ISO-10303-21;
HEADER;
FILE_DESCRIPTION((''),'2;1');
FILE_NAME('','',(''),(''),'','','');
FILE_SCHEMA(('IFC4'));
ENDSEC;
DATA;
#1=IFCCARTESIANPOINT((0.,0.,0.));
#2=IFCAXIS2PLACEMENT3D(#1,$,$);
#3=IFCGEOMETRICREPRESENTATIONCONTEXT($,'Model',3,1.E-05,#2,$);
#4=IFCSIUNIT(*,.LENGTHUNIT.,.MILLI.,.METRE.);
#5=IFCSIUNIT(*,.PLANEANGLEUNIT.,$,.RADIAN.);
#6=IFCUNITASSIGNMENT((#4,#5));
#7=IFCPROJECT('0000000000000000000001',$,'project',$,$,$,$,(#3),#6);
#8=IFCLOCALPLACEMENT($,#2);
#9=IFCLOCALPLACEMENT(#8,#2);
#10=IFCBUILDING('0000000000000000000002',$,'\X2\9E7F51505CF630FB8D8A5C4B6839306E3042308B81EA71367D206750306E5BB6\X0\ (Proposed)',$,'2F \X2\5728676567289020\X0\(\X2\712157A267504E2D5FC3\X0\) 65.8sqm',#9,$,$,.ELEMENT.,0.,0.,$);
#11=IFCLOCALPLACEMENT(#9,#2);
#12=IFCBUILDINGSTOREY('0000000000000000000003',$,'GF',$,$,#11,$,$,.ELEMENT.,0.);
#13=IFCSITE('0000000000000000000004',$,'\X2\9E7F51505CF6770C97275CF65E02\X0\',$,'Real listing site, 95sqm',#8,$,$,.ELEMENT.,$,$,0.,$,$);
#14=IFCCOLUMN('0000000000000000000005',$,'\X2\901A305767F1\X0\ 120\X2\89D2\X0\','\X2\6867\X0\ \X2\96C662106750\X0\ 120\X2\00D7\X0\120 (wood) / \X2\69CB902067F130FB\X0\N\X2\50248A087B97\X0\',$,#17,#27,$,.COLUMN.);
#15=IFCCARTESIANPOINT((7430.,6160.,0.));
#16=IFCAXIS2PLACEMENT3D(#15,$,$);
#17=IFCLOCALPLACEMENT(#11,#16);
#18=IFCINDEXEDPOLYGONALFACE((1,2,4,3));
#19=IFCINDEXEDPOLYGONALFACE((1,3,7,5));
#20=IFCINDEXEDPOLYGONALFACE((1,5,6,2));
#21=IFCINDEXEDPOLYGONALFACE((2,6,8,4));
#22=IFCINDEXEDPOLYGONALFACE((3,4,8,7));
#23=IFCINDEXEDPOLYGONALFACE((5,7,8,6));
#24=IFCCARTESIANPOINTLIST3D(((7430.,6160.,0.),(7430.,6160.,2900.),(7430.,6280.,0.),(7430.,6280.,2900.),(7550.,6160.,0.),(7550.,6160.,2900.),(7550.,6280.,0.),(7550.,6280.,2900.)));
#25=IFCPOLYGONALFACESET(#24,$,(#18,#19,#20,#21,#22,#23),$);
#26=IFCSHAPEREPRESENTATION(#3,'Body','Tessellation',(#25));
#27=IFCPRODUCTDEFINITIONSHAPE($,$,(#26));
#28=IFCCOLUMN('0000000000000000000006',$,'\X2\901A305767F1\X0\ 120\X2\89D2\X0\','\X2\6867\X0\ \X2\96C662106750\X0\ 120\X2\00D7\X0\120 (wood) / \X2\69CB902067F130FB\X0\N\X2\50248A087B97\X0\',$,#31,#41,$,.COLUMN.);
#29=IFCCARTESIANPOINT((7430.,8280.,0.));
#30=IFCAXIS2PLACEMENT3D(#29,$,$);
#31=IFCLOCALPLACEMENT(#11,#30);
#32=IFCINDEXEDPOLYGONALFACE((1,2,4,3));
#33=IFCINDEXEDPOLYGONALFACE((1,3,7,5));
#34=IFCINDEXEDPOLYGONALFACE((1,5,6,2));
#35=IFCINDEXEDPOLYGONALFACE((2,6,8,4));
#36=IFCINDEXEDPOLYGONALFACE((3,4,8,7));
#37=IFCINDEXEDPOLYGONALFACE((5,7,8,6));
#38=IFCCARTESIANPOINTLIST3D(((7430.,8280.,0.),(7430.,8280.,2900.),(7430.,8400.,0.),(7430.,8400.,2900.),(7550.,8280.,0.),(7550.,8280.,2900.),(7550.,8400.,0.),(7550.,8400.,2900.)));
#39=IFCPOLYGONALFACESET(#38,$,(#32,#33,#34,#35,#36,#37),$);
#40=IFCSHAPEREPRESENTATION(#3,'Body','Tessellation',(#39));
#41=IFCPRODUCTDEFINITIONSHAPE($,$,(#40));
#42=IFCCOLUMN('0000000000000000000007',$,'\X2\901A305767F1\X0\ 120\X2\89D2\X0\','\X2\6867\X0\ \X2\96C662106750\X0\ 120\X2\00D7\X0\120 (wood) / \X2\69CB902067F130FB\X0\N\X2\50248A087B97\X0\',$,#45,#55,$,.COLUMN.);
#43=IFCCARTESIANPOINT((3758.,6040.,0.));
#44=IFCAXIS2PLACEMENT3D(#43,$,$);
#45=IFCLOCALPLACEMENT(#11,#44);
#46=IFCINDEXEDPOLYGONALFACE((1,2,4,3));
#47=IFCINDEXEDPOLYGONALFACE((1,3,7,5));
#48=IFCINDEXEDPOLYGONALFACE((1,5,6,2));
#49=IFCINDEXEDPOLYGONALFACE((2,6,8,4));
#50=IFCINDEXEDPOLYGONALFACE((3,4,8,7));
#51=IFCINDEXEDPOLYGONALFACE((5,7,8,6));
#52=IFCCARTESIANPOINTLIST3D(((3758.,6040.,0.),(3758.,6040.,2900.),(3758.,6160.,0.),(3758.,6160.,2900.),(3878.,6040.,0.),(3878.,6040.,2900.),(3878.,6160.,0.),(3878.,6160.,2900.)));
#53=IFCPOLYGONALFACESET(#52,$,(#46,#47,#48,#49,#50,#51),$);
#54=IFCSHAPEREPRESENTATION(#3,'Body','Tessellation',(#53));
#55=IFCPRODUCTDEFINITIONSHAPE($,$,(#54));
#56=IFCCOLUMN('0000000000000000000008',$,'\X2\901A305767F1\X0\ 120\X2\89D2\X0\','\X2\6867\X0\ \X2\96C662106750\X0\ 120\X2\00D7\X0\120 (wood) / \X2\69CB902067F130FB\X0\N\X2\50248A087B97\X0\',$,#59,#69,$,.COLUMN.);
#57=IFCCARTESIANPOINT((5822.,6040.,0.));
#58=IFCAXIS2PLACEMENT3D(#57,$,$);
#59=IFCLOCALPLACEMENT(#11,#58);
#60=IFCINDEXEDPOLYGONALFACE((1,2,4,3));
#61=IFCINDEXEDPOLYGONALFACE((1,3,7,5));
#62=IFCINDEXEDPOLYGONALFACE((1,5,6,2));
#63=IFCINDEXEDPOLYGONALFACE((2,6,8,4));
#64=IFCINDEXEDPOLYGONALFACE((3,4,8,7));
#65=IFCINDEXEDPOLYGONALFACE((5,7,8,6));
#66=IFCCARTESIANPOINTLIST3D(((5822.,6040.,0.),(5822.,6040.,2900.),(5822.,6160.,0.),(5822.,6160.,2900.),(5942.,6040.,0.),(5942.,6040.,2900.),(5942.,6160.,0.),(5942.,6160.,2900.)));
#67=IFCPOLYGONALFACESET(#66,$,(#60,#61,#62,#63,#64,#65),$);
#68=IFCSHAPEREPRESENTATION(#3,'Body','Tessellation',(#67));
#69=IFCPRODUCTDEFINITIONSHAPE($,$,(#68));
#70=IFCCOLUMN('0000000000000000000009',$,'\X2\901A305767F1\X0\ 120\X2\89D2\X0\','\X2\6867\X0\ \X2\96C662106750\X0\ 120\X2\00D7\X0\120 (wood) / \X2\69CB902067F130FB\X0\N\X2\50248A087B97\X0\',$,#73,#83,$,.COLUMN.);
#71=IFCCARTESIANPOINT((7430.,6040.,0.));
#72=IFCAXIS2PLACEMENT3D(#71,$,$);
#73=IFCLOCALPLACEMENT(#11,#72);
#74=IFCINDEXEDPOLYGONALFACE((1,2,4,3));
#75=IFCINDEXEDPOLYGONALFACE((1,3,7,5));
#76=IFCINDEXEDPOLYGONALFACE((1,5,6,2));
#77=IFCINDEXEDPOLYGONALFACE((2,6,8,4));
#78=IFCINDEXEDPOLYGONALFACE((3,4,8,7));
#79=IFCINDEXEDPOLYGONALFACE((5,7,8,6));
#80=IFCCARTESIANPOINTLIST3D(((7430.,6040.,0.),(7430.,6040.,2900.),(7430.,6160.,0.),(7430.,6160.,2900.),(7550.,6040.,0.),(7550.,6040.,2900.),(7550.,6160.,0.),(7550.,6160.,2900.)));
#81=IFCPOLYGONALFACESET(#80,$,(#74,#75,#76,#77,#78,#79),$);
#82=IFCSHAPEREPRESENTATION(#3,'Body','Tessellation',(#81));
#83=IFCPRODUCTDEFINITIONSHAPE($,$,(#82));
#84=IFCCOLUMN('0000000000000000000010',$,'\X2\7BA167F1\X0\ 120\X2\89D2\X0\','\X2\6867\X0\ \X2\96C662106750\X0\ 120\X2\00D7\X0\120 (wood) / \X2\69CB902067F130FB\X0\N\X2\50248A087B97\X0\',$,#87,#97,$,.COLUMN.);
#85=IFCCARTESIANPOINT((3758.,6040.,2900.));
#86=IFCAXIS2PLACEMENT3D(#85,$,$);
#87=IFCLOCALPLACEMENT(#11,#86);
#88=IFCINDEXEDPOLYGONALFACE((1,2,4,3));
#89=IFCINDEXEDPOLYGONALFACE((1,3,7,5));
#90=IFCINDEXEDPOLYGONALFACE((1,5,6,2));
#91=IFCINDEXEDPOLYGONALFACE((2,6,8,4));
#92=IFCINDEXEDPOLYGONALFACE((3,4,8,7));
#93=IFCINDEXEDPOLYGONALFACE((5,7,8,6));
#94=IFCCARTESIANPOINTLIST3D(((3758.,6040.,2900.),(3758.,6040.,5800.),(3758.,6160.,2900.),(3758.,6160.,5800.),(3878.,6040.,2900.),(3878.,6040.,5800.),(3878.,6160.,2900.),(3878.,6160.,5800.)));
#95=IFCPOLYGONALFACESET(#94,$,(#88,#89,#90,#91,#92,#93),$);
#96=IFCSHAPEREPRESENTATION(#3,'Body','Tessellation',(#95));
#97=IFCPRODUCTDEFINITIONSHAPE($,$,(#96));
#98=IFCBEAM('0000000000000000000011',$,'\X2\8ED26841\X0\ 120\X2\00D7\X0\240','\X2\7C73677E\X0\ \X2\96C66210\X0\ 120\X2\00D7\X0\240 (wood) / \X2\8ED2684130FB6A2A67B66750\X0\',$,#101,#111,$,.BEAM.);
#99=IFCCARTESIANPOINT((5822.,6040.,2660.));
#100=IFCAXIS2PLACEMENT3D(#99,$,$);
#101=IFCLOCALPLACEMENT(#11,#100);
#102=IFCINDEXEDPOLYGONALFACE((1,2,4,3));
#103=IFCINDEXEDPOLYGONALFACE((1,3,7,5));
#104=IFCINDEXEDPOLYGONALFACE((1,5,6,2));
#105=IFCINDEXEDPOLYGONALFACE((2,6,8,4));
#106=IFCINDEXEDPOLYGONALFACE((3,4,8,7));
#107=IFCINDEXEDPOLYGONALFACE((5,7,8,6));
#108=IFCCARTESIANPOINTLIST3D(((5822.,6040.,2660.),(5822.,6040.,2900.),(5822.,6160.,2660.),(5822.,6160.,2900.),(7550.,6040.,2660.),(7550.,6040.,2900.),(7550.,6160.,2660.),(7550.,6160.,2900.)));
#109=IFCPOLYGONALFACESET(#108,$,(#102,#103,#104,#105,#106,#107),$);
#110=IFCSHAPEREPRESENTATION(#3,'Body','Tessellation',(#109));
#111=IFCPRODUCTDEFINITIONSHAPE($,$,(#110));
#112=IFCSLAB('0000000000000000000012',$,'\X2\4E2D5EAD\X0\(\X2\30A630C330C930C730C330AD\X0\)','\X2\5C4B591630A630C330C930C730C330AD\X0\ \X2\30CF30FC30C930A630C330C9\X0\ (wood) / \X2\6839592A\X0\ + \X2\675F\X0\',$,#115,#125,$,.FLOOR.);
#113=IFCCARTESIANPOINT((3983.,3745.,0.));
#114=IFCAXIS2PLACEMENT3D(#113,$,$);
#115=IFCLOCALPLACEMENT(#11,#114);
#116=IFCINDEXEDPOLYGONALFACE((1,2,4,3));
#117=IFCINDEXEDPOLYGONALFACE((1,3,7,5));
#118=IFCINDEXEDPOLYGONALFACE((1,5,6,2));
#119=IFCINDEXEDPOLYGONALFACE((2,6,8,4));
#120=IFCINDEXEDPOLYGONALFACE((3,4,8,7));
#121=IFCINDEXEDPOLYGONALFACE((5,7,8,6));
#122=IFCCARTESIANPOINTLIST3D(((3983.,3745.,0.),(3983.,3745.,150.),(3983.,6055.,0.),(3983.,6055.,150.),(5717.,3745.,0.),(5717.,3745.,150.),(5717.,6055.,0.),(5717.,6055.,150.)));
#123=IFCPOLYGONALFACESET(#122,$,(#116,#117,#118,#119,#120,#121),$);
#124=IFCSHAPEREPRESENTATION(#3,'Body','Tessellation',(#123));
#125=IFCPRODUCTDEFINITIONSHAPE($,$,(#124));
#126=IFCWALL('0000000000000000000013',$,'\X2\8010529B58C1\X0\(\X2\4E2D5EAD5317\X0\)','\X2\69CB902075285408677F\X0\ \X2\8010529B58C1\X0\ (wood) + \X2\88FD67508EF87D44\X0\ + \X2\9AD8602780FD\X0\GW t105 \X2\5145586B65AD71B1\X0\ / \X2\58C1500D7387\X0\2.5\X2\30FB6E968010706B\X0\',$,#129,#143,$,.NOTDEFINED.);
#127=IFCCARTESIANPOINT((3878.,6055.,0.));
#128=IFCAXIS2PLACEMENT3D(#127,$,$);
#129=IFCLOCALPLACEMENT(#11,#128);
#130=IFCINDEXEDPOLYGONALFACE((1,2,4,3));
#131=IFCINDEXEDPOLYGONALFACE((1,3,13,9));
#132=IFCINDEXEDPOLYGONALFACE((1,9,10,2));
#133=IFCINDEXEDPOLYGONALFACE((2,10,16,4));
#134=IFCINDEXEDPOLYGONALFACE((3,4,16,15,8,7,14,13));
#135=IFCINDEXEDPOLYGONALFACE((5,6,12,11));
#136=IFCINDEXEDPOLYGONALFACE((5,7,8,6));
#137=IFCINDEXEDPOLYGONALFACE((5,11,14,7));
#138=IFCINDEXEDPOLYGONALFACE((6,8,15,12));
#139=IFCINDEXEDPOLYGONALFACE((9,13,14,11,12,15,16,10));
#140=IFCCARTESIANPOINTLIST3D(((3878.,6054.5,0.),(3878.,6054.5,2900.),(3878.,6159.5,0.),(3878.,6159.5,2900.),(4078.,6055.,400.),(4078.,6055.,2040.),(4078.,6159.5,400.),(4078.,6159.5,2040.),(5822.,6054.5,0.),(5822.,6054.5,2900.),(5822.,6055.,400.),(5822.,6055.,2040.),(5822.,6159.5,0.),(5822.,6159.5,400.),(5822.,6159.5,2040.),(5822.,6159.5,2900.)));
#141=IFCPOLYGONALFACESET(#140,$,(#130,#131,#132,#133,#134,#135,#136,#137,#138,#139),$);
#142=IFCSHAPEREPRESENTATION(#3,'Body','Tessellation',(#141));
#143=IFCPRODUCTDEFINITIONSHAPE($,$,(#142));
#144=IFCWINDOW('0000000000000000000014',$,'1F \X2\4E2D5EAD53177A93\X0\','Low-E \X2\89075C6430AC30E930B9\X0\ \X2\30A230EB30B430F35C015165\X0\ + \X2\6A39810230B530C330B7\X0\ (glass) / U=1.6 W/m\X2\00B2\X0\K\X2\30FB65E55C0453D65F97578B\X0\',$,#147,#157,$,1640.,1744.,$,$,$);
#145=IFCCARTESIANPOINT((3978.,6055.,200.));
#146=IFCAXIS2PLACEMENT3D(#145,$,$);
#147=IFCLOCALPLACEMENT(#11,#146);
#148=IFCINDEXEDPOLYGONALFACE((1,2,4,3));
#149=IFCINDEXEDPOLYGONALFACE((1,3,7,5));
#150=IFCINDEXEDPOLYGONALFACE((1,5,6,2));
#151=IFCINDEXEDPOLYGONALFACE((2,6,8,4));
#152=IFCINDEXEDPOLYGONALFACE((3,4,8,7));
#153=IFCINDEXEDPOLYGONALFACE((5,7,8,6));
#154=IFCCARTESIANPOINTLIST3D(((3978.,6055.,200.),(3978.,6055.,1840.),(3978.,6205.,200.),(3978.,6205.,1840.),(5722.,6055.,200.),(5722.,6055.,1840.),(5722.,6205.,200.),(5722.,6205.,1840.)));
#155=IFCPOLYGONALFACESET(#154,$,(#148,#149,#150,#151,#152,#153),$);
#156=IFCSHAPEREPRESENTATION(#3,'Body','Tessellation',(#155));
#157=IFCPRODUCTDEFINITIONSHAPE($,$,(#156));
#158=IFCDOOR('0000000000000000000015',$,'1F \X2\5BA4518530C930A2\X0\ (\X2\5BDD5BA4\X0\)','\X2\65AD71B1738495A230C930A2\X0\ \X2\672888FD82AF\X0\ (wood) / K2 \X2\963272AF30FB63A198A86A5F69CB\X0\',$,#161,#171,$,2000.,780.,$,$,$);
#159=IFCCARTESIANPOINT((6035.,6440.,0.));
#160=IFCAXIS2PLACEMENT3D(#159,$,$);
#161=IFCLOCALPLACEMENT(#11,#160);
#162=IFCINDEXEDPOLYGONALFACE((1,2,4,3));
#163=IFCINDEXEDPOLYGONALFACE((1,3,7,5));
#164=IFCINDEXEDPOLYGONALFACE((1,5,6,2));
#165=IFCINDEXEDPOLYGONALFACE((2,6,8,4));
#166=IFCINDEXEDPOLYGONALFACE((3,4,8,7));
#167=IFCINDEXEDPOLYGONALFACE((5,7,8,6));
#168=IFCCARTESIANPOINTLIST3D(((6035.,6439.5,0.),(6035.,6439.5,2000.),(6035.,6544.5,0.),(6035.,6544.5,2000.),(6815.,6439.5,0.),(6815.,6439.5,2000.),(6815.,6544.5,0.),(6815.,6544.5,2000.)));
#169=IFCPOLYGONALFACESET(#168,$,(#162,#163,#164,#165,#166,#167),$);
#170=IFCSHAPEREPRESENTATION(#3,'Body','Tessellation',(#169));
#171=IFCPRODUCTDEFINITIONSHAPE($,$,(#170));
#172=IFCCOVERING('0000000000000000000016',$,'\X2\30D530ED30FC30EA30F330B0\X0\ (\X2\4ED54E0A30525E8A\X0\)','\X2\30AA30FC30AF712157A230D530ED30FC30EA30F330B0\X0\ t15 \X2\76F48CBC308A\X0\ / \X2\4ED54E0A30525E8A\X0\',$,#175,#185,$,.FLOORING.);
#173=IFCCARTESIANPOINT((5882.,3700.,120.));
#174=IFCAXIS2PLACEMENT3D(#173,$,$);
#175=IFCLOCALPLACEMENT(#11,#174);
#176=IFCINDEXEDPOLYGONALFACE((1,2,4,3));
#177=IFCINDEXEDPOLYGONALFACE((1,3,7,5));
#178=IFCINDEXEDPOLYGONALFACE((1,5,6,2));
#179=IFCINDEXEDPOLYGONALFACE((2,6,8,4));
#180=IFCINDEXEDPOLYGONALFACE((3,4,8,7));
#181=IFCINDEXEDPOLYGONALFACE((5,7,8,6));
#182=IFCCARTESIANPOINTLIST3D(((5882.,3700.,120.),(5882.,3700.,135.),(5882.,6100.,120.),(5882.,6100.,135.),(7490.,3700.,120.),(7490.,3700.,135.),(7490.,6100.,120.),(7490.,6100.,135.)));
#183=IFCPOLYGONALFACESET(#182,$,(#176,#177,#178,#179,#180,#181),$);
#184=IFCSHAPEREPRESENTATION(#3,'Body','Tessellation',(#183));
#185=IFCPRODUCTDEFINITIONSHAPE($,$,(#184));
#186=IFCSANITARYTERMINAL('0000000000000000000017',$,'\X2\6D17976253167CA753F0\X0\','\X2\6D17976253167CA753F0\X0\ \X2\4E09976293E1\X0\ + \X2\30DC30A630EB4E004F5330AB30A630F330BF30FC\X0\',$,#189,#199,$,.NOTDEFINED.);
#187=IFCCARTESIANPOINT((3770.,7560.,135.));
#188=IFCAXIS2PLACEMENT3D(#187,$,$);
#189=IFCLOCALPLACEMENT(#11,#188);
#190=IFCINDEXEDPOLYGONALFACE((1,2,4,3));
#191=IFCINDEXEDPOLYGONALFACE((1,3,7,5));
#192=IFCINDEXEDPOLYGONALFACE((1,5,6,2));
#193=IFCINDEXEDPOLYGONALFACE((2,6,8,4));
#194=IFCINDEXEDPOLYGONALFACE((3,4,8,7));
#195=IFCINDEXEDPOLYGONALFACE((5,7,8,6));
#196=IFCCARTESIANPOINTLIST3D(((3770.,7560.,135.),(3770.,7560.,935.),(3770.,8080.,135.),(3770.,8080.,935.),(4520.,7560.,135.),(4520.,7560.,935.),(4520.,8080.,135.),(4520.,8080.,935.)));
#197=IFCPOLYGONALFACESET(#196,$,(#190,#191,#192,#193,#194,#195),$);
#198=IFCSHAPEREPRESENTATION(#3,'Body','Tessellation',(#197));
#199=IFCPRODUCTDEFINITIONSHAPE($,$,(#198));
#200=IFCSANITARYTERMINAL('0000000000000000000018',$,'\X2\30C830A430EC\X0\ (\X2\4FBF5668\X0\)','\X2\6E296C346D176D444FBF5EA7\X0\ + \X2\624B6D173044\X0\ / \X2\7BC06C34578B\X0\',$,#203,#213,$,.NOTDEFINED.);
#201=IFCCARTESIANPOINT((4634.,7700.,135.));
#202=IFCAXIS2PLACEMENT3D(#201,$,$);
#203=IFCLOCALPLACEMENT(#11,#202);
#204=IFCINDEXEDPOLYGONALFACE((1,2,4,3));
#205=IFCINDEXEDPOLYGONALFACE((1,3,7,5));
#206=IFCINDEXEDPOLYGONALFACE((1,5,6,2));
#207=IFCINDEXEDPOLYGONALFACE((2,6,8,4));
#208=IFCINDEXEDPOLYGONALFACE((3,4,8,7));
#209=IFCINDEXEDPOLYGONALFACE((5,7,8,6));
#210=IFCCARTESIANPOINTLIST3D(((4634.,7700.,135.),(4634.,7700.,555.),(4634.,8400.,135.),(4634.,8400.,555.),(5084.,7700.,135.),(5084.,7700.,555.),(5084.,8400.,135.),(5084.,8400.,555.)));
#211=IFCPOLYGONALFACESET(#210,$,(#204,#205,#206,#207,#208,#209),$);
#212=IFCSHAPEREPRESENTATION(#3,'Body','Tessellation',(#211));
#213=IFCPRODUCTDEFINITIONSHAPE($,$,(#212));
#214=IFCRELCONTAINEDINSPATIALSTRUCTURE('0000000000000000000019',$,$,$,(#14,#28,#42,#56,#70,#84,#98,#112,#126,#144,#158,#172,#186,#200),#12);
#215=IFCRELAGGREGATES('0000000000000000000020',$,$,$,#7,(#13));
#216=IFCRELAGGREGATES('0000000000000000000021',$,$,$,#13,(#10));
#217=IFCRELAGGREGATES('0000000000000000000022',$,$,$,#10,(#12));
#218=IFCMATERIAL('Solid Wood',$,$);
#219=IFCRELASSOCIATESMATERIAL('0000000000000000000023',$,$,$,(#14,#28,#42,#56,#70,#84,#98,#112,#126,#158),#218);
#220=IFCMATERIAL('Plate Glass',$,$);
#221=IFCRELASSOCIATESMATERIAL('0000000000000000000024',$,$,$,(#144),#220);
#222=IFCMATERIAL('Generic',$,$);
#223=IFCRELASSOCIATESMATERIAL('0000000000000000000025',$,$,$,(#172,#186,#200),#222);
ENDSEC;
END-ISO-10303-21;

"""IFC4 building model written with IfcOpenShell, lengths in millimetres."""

from ifc_helpers import new_model, si_unit, frame, frame_2d, origin, place, context, project, spatial, rectangle, extrude, material, element, fill, save


model = new_model("IFC4")

# Units and contexts
model_context = context("Model", 3, precision=1e-05, world=origin())
ifc_project = project(units=[si_unit("LENGTHUNIT", "METRE", prefix="MILLI"), si_unit("PLANEANGLEUNIT", "RADIAN")], contexts=[model_context])

# Site, building, storey
site_placement = place(None, origin())
site = spatial("IfcSite", under=ifc_project, at=site_placement, Name="鹿児島県霧島市", ObjectType="Real listing site, 95sqm", CompositionType="ELEMENT", RefElevation=0.0)
building_placement = place(site_placement, origin())
building = spatial("IfcBuilding", under=site, at=building_placement, Name="鹿児島・越屋根のある自然素材の家 (Proposed)", ObjectType="2F 在来木造(無垢材中心) 65.8sqm", CompositionType="ELEMENT", ElevationOfRefHeight=0.0, ElevationOfTerrain=0.0)
storey_placement = place(building_placement, origin())
storey = spatial("IfcBuildingStorey", under=building, at=storey_placement, Name="GF", CompositionType="ELEMENT", Elevation=0.0)

# Columns
ifc_material_1 = material(Name="Solid Wood")
column_1_placement = place(storey_placement, frame((7430.0, 6160.0, 0.0)))
element("IfcColumn", 1, at=column_1_placement, inside=storey, material=ifc_material_1, Name="通し柱 120角", Description="桧 集成材 120×120 (wood) / 構造柱・N値計算", PredefinedType="COLUMN", context=model_context, shape_type="SweptSolid", body=[
    extrude(rectangle(XDim=120.0, YDim=120.0, at=frame_2d((60.0, 60.0))), frame((7430.0, 6160.0, 0.0)), (0.0, 0.0, 1.0), 2900.0),
])
column_2_placement = place(storey_placement, frame((7430.0, 8280.0, 0.0)))
element("IfcColumn", 2, at=column_2_placement, inside=storey, material=ifc_material_1, Name="通し柱 120角", Description="桧 集成材 120×120 (wood) / 構造柱・N値計算", PredefinedType="COLUMN", context=model_context, shape_type="SweptSolid", body=[
    extrude(rectangle(XDim=120.0, YDim=120.0, at=frame_2d((60.0, 60.0))), frame((7430.0, 8280.0, 0.0)), (0.0, 0.0, 1.0), 2900.0),
])
column_3_placement = place(storey_placement, frame((3758.0, 6040.0, 0.0)))
element("IfcColumn", 3, at=column_3_placement, inside=storey, material=ifc_material_1, Name="通し柱 120角", Description="桧 集成材 120×120 (wood) / 構造柱・N値計算", PredefinedType="COLUMN", context=model_context, shape_type="SweptSolid", body=[
    extrude(rectangle(XDim=120.0, YDim=120.0, at=frame_2d((60.0, 60.0))), frame((3758.0, 6040.0, 0.0)), (0.0, 0.0, 1.0), 2900.0),
])
column_4_placement = place(storey_placement, frame((5822.0, 6040.0, 0.0)))
element("IfcColumn", 4, at=column_4_placement, inside=storey, material=ifc_material_1, Name="通し柱 120角", Description="桧 集成材 120×120 (wood) / 構造柱・N値計算", PredefinedType="COLUMN", context=model_context, shape_type="SweptSolid", body=[
    extrude(rectangle(XDim=120.0, YDim=120.0, at=frame_2d((60.0, 60.0))), frame((5822.0, 6040.0, 0.0)), (0.0, 0.0, 1.0), 2900.0),
])
column_5_placement = place(storey_placement, frame((7430.0, 6040.0, 0.0)))
element("IfcColumn", 5, at=column_5_placement, inside=storey, material=ifc_material_1, Name="通し柱 120角", Description="桧 集成材 120×120 (wood) / 構造柱・N値計算", PredefinedType="COLUMN", context=model_context, shape_type="SweptSolid", body=[
    extrude(rectangle(XDim=120.0, YDim=120.0, at=frame_2d((60.0, 60.0))), frame((7430.0, 6040.0, 0.0)), (0.0, 0.0, 1.0), 2900.0),
])
column_6_placement = place(storey_placement, frame((3758.0, 6040.0, 2900.0)))
element("IfcColumn", 6, at=column_6_placement, inside=storey, material=ifc_material_1, Name="管柱 120角", Description="桧 集成材 120×120 (wood) / 構造柱・N値計算", PredefinedType="COLUMN", context=model_context, shape_type="SweptSolid", body=[
    extrude(rectangle(XDim=120.0, YDim=120.0, at=frame_2d((60.0, 60.0))), frame((3758.0, 6040.0, 2900.0)), (0.0, 0.0, 1.0), 2900.0),
])

# Beam
beam_1_placement = place(storey_placement, frame((5822.0, 6040.0, 2660.0)))
element("IfcBeam", 7, at=beam_1_placement, inside=storey, material=ifc_material_1, Name="軒桁 120×240", Description="米松 集成 120×240 (wood) / 軒桁・横架材", PredefinedType="BEAM", context=model_context, shape_type="SweptSolid", body=[
    extrude(rectangle(XDim=1728.0, YDim=120.0, at=frame_2d((864.0, 60.0))), frame((5822.0, 6040.0, 2660.0)), (0.0, 0.0, 1.0), 240.0),
])

# Slab
slab_placement = place(storey_placement, frame((3983.0, 3745.0, 0.0)))
element("IfcSlab", 8, at=slab_placement, inside=storey, material=ifc_material_1, Name="中庭(ウッドデッキ)", Description="屋外ウッドデッキ ハードウッド (wood) / 根太 + 束", PredefinedType="FLOOR", context=model_context, shape_type="SweptSolid", body=[
    extrude(rectangle(XDim=1734.0, YDim=2310.0, at=frame_2d((867.0, 1155.0))), frame((3983.0, 3745.0, 0.0)), (0.0, 0.0, 1.0), 150.0),
])

# Wall, opening, window
wall_1_placement = place(storey_placement, frame((3878.0, 6055.0, 0.0)))
wall_1 = element("IfcWall", 9, at=wall_1_placement, inside=storey, material=ifc_material_1, Name="耐力壁(中庭北)", Description="構造用合板 耐力壁 (wood) + 製材軸組 + 高性能GW t105 充填断熱 / 壁倍率2.5・準耐火", PredefinedType="NOTDEFINED", context=model_context, shape_type="SweptSolid", body=[
    extrude(rectangle(XDim=1944.0, YDim=105.0, at=frame_2d((972.0, 52.0))), frame((3878.0, 6055.0, 0.0)), (0.0, 0.0, 1.0), 2900.0),
])
opening_placement = place(storey_placement, frame((3978.0, 6055.0, 200.0)))
opening = element("IfcOpeningElement", 10, at=opening_placement, cuts=wall_1, PredefinedType="NOTDEFINED", context=model_context, shape_type="SweptSolid", body=[
    extrude(rectangle(XDim=1744.0, YDim=150.0, at=frame_2d((872.0, 75.0))), frame((3978.0, 6055.0, 200.0)), (0.0, 0.0, 1.0), 1640.0),
])
ifc_material_2 = material(Name="Plate Glass")
window_placement = place(storey_placement, frame((3978.0, 6055.0, 200.0)))
window = element("IfcWindow", 11, at=window_placement, inside=storey, material=ifc_material_2, Name="1F 中庭北窓", Description="Low-E 複層ガラス アルゴン封入 + 樹脂サッシ (glass) / U=1.6 W/m²K・日射取得型", OverallHeight=1640.0, OverallWidth=1744.0, context=model_context, shape_type="SweptSolid", body=[
    extrude(rectangle(XDim=1744.0, YDim=150.0, at=frame_2d((872.0, 75.0))), frame((3978.0, 6055.0, 200.0)), (0.0, 0.0, 1.0), 1640.0),
])
fill(opening, window)

# Door
door_placement = place(storey_placement, frame((6035.0, 6440.0, 0.0)))
element("IfcDoor", 12, at=door_placement, inside=storey, material=ifc_material_1, Name="1F 室内ドア (寝室)", Description="断熱玄関ドア 木製芯 (wood) / K2 防犯・採風機構", OverallHeight=2000.0, OverallWidth=780.0, context=model_context, shape_type="SweptSolid", body=[
    extrude(rectangle(XDim=780.0, YDim=105.0, at=frame_2d((390.0, 52.0))), frame((6035.0, 6440.0, 0.0)), (0.0, 0.0, 1.0), 2000.0),
])

# Covering
ifc_material_3 = material(Name="Generic")
covering_placement = place(storey_placement, frame((5882.0, 3700.0, 120.0)))
element("IfcCovering", 13, at=covering_placement, inside=storey, material=ifc_material_3, Name="フローリング (仕上げ床)", Description="オーク無垢フローリング t15 直貼り / 仕上げ床", PredefinedType="FLOORING", context=model_context, shape_type="SweptSolid", body=[
    extrude(rectangle(XDim=1608.0, YDim=2400.0, at=frame_2d((804.0, 1200.0))), frame((5882.0, 3700.0, 120.0)), (0.0, 0.0, 1.0), 15.0),
])

# Sanitary terminals
sanitary_terminal_1_placement = place(storey_placement, frame((3770.0, 7560.0, 135.0)))
element("IfcSanitaryTerminal", 14, at=sanitary_terminal_1_placement, inside=storey, material=ifc_material_3, Name="洗面化粧台", Description="洗面化粧台 三面鏡 + ボウル一体カウンター", PredefinedType="NOTDEFINED", context=model_context, shape_type="SweptSolid", body=[
    extrude(rectangle(XDim=750.0, YDim=520.0, at=frame_2d((375.0, 260.0))), frame((3770.0, 7560.0, 135.0)), (0.0, 0.0, 1.0), 800.0),
])
sanitary_terminal_2_placement = place(storey_placement, frame((4634.0, 7700.0, 135.0)))
element("IfcSanitaryTerminal", 15, at=sanitary_terminal_2_placement, inside=storey, material=ifc_material_3, Name="トイレ (便器)", Description="温水洗浄便座 + 手洗い / 節水型", PredefinedType="NOTDEFINED", context=model_context, shape_type="SweptSolid", body=[
    extrude(rectangle(XDim=450.0, YDim=700.0, at=frame_2d((225.0, 350.0))), frame((4634.0, 7700.0, 135.0)), (0.0, 0.0, 1.0), 420.0),
])

save(model, "model.ifc")
